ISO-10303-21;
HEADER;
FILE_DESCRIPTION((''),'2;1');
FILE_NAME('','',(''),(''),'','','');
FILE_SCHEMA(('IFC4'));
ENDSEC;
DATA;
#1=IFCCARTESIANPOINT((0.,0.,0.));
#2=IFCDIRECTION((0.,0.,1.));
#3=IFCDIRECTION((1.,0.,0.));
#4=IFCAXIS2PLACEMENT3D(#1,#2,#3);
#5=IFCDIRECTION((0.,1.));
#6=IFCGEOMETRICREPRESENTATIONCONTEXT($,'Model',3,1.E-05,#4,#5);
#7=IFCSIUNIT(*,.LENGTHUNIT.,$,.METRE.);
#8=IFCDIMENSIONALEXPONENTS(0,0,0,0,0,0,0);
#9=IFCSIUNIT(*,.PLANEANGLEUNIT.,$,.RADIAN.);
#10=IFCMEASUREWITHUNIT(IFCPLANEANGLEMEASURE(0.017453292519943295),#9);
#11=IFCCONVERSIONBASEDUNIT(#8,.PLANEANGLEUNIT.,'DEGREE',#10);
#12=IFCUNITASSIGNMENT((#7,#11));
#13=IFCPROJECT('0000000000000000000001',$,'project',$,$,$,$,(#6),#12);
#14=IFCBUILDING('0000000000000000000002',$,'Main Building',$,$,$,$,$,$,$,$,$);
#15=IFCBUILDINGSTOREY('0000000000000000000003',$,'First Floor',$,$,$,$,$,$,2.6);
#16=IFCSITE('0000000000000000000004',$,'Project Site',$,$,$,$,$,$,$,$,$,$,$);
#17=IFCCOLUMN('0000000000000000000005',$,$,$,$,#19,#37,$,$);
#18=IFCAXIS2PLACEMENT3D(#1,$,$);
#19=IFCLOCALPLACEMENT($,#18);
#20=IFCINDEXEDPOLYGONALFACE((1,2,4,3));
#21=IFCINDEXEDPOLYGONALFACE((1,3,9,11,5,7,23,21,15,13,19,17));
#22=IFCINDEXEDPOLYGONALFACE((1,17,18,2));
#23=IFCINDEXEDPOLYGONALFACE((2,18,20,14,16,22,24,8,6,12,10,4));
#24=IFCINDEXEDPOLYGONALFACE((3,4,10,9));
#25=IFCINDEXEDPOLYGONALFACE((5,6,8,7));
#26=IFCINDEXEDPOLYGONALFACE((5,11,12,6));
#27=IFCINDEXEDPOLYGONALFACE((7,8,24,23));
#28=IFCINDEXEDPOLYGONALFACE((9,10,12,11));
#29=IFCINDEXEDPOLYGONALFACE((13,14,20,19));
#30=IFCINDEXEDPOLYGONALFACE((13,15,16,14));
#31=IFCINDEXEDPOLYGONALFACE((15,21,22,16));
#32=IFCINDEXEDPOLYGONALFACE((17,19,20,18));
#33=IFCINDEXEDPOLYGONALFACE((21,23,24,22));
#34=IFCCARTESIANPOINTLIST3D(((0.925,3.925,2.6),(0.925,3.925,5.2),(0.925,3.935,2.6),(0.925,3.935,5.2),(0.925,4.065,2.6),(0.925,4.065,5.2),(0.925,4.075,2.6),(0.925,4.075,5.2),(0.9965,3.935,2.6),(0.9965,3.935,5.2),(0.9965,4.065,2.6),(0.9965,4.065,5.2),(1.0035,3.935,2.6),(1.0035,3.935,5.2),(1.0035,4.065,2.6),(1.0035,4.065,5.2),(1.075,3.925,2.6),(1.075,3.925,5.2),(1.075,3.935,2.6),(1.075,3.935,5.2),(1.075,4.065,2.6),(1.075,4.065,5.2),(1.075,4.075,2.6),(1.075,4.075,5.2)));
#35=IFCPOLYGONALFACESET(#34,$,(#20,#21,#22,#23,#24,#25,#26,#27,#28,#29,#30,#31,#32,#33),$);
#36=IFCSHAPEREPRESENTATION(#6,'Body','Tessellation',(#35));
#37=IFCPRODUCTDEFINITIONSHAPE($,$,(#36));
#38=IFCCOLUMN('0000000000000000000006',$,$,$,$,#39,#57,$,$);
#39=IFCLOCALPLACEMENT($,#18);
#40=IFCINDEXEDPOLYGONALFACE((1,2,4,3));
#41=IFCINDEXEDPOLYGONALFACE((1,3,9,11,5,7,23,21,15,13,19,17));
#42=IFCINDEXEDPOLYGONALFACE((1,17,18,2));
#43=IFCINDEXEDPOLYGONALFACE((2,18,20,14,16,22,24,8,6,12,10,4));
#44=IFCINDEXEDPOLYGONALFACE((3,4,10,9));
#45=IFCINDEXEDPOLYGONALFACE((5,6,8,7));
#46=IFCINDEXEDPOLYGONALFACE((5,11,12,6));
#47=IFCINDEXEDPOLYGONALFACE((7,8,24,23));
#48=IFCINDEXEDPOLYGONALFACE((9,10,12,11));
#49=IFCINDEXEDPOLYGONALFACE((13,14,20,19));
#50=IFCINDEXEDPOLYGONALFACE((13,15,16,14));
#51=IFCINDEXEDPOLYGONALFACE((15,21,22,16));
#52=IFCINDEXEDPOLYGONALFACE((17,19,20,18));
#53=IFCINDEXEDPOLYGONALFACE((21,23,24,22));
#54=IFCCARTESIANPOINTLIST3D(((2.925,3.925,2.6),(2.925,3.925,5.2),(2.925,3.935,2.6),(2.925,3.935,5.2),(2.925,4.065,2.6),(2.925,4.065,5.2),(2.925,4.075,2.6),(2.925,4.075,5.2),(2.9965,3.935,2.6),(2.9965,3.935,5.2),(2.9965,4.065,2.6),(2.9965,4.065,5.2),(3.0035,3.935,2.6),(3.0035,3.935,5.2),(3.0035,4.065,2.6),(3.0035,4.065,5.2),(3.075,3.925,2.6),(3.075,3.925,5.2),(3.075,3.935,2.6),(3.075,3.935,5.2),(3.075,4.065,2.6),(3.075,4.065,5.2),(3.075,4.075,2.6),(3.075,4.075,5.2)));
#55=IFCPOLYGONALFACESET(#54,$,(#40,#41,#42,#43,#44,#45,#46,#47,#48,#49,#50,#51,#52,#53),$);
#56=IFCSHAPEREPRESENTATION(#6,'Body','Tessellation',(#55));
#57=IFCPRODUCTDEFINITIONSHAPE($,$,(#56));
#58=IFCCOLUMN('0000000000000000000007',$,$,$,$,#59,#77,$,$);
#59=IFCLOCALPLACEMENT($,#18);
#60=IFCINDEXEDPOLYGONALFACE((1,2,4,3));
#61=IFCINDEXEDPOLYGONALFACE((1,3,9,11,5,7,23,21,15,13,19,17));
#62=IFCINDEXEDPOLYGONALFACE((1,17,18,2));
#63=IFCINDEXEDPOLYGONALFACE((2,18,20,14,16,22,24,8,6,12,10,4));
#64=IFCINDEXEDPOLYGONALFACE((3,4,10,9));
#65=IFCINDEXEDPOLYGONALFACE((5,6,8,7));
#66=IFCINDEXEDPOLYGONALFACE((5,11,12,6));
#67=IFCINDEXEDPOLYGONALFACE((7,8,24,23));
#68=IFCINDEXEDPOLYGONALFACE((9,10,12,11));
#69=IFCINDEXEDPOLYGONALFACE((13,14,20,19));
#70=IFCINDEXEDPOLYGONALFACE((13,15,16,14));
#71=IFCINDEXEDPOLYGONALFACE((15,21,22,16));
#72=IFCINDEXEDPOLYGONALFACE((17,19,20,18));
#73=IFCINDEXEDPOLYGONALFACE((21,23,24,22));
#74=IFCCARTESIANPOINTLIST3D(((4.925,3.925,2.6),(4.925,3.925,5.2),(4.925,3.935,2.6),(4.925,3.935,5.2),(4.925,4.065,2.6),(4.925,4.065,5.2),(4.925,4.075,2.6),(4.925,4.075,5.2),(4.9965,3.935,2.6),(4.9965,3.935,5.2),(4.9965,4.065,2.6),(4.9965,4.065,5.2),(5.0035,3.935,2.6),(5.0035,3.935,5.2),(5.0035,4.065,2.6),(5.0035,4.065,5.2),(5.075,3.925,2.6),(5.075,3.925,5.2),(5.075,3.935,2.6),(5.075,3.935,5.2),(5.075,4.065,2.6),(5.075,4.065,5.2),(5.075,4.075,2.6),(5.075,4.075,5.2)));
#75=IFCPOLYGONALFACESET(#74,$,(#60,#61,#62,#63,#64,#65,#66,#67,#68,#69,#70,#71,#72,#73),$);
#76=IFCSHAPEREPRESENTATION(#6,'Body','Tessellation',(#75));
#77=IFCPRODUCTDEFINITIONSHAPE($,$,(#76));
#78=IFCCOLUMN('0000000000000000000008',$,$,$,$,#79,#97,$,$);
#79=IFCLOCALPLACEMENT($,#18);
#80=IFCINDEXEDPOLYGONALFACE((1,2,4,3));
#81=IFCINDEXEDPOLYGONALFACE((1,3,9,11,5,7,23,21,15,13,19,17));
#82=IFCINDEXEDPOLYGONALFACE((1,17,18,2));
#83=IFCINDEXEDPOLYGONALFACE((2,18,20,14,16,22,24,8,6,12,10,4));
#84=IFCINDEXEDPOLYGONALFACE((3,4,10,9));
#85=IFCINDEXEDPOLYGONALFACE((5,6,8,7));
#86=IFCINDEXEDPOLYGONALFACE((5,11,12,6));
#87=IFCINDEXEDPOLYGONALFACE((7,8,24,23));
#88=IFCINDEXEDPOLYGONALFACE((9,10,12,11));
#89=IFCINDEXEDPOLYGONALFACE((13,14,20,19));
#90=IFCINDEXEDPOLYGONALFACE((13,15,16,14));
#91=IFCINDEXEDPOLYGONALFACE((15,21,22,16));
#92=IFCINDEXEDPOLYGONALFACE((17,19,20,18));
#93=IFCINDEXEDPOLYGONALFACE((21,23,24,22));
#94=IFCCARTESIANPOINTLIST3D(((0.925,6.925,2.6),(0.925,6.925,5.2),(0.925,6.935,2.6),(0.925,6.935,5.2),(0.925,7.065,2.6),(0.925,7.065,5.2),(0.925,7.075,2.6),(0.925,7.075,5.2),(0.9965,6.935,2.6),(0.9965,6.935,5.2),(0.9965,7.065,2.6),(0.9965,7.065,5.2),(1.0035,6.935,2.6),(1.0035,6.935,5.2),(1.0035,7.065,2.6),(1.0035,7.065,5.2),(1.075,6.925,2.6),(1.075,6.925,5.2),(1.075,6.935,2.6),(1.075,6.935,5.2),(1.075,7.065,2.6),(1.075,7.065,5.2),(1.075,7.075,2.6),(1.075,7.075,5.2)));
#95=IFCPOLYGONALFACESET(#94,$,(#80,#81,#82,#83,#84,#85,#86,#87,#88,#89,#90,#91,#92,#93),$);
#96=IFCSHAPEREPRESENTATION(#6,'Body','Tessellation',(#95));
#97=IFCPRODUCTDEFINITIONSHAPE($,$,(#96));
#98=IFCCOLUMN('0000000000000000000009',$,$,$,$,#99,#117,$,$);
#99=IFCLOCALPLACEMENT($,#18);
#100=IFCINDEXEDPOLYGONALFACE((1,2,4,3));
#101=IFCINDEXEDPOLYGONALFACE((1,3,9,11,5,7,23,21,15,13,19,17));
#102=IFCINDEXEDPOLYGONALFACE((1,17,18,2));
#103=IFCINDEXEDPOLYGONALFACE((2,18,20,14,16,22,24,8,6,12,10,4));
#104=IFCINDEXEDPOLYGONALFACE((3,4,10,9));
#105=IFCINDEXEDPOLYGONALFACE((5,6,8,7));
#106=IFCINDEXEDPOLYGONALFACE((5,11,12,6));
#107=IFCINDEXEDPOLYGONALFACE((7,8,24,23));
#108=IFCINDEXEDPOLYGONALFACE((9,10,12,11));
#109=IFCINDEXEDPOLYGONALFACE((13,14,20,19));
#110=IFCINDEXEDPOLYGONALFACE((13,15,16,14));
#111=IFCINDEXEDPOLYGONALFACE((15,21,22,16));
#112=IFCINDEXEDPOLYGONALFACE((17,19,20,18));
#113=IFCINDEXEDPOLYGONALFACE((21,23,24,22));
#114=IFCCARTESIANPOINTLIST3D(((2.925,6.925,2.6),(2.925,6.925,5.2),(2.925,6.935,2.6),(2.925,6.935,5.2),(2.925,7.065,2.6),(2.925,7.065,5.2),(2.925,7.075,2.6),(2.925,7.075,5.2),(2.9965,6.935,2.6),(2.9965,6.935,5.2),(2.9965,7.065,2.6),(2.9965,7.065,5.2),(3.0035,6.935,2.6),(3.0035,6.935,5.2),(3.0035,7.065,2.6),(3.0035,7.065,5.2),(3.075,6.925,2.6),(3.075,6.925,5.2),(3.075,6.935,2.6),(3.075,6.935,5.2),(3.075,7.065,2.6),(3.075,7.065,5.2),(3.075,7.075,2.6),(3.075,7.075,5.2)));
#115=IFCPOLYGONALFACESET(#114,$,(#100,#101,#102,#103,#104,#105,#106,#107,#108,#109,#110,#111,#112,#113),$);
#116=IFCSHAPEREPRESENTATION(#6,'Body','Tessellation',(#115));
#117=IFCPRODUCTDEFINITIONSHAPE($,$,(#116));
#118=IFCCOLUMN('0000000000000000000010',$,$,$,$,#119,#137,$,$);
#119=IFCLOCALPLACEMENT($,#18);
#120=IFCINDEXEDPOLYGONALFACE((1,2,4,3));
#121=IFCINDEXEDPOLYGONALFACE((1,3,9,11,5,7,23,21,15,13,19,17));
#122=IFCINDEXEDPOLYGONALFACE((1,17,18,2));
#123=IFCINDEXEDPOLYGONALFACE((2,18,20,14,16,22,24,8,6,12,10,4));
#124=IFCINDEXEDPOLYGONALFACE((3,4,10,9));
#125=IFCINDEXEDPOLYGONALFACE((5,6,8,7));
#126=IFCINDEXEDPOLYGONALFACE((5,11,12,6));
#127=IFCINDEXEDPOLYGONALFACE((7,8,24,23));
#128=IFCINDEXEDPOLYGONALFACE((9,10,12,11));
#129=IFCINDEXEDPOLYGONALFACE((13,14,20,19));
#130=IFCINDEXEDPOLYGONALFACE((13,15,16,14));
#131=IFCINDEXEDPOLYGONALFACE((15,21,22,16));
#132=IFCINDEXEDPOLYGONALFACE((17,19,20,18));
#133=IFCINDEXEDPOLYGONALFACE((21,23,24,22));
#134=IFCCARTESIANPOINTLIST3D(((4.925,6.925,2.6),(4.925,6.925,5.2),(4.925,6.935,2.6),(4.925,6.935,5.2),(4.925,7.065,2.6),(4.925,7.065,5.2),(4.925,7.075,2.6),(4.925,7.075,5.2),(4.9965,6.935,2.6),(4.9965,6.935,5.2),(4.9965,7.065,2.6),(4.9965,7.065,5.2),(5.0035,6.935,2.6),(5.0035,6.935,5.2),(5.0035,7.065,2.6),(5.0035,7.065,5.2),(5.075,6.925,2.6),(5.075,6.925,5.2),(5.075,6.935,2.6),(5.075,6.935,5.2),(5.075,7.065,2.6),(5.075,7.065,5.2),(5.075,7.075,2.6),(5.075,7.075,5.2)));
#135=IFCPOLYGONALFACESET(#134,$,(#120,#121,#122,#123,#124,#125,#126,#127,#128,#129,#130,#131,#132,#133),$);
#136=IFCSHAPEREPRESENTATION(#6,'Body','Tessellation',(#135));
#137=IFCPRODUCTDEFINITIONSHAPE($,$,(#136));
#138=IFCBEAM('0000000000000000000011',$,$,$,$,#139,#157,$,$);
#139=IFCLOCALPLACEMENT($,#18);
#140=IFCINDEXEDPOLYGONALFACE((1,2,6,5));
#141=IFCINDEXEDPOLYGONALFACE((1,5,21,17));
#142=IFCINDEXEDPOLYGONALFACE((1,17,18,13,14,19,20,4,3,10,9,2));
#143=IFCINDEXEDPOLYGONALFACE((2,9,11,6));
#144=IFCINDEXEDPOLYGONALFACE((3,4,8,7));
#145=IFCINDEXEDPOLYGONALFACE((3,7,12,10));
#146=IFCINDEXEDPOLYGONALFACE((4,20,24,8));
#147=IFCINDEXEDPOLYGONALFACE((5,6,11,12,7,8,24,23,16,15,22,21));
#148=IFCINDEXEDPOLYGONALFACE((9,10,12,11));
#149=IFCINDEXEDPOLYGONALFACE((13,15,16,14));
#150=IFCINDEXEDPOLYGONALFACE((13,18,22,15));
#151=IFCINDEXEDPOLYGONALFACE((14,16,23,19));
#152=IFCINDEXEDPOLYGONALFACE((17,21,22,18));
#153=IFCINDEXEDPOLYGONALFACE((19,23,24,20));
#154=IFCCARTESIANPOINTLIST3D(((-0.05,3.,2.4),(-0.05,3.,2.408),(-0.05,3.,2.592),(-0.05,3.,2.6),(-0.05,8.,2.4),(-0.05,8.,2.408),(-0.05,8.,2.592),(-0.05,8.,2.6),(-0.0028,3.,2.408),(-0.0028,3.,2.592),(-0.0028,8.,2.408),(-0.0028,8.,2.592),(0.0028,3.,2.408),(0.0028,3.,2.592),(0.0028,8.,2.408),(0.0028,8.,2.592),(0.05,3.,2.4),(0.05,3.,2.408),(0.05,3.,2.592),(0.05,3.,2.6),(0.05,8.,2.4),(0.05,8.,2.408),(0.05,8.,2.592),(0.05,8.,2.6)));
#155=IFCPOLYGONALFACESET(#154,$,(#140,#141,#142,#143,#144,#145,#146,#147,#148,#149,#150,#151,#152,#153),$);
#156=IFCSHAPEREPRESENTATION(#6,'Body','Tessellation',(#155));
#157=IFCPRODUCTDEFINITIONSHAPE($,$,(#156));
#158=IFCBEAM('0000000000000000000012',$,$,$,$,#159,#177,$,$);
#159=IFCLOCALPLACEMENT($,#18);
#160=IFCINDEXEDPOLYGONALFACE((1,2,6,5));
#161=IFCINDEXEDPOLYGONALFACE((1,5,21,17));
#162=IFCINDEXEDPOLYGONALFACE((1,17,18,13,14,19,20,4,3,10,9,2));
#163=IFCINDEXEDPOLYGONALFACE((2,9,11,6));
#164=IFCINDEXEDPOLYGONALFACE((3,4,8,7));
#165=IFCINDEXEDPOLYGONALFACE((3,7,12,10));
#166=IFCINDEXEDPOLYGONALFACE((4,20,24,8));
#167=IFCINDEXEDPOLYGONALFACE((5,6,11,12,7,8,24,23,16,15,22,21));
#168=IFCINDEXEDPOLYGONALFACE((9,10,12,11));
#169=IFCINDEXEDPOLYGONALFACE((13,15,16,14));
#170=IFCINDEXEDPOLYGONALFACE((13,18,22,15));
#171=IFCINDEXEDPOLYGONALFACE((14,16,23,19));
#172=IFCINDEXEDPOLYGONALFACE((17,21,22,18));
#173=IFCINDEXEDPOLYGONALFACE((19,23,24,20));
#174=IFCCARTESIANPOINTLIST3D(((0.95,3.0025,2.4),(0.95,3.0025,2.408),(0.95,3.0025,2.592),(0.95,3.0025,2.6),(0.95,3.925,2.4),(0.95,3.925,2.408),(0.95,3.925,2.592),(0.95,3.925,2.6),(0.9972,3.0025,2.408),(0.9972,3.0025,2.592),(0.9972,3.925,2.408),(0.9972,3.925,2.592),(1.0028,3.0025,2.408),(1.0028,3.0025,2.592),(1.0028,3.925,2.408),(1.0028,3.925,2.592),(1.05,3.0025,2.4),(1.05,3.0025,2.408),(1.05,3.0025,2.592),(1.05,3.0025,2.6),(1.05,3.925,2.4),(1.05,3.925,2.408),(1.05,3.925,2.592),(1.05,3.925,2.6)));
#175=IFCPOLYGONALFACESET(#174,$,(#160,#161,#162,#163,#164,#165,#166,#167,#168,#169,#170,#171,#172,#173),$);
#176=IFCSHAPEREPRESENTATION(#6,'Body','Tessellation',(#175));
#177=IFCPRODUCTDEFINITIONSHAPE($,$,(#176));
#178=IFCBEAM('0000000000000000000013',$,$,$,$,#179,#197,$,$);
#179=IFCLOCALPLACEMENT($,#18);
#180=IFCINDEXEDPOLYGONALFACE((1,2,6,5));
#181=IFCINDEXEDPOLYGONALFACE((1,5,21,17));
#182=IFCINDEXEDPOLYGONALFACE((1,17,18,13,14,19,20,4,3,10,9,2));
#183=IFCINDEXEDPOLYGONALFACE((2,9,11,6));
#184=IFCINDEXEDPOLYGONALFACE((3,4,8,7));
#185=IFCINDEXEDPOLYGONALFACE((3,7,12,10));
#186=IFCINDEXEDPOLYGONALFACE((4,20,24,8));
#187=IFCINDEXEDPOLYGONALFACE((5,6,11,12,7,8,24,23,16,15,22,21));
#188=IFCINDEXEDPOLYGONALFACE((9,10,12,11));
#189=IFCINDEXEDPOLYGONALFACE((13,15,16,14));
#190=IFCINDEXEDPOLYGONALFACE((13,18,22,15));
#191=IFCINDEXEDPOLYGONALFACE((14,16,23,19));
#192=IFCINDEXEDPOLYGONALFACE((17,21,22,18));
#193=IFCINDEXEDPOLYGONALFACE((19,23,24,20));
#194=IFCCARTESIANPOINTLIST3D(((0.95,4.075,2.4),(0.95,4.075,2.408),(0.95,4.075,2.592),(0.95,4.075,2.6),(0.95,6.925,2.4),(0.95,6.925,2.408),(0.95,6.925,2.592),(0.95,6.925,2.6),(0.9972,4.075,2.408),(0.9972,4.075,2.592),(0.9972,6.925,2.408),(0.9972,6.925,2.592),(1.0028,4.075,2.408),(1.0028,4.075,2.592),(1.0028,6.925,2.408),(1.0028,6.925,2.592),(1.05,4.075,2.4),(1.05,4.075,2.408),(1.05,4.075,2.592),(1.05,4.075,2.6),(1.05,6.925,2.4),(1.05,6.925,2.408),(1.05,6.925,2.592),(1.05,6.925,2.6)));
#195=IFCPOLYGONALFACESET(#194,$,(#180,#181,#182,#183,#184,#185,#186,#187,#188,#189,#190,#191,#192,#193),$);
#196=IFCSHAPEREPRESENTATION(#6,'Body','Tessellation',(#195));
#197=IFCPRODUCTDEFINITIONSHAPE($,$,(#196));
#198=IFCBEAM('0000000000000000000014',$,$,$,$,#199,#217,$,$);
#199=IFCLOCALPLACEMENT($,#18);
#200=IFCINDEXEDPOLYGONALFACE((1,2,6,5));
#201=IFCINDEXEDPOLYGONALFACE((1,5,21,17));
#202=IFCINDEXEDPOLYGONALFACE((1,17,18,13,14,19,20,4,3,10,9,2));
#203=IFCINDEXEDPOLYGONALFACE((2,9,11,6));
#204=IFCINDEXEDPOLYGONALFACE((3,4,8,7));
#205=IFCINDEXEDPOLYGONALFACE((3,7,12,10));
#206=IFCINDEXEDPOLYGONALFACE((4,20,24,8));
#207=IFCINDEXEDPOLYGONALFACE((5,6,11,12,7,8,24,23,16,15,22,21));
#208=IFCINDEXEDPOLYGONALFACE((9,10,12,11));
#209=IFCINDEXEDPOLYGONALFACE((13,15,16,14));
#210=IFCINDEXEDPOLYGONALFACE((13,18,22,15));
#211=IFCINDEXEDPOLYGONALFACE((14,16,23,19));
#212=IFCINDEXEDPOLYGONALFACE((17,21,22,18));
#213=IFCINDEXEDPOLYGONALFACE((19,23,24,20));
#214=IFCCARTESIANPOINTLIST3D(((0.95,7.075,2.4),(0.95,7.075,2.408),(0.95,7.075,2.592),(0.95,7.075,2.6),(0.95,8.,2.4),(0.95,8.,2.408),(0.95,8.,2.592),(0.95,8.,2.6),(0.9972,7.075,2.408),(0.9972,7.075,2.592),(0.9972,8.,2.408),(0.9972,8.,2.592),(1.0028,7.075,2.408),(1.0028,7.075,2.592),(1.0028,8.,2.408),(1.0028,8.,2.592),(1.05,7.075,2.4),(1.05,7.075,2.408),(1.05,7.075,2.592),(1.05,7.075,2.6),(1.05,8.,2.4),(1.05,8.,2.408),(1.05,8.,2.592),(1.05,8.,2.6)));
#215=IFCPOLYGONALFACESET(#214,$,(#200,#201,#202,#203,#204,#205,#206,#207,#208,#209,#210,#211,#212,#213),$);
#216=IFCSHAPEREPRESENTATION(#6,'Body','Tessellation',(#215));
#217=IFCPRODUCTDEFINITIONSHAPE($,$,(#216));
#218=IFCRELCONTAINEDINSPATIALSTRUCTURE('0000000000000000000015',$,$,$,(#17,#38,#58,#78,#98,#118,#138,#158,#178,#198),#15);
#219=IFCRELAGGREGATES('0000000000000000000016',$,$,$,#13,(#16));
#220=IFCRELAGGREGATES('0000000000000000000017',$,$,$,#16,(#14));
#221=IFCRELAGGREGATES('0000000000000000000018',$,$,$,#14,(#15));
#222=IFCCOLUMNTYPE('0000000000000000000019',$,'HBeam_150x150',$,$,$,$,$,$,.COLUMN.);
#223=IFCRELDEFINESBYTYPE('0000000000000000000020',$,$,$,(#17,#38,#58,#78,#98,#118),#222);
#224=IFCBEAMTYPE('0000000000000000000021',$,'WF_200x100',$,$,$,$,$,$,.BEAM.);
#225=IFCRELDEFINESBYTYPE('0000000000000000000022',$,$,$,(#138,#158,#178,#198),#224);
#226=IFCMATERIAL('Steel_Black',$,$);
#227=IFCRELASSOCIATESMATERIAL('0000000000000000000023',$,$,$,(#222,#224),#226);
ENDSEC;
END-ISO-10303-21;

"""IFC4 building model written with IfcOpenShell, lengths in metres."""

from ifc_helpers import new_model, entity, si_unit, converted_unit, direction, frame, frame_2d, origin, origin_with_axes, origin_2d, place, context, project, spatial, i_section, extrude, material, material_profile, profile_set, type_object, element, save


model = new_model("IFC4")

# Units and contexts
model_context = context("Model", 3, precision=1e-05, world=origin_with_axes(), true_north=direction((0.0, 1.0)))
ifc_project = project(units=[si_unit("LENGTHUNIT", "METRE"), converted_unit("PLANEANGLEUNIT", "DEGREE", entity("IfcPlaneAngleMeasure", 0.017453292519943295), si_unit("PLANEANGLEUNIT", "RADIAN"), dimensions=[0, 0, 0, 0, 0, 0, 0])], contexts=[model_context])

# Site, building, storey
site = spatial("IfcSite", under=ifc_project, Name="Project Site")
building = spatial("IfcBuilding", under=site, Name="Main Building")
storey = spatial("IfcBuildingStorey", under=building, Name="First Floor", Elevation=2.6)

# Columns
ifc_material_1 = material(Name="Steel_Black")
ifc_material_profile_1 = material_profile(ifc_material_1, i_section(OverallWidth=0.15, OverallDepth=0.15, WebThickness=0.007, FlangeThickness=0.01, at=origin_2d()), Name="HBeam_150x150")
ifc_profile_set_1 = profile_set([ifc_material_profile_1], Name="HBeam_150x150")
column_type = type_object("IfcColumnType", Name="HBeam_150x150", PredefinedType="COLUMN", material=ifc_profile_set_1)
for number, where, z_axis, x_axis in (
    (1, (1.0, 4.0, 2.6), (0.0, 0.0, 1.0), (1.0, 0.0, 0.0)),
    (2, (3.0, 4.0, 2.6), (0.0, 0.0, 1.0), (1.0, 0.0, 0.0)),
    (3, (5.0, 4.0, 2.6), (0.0, 0.0, 1.0), (1.0, 0.0, 0.0)),
    (4, (1.0, 7.0, 2.6), (0.0, 0.0, 1.0), (1.0, 0.0, 0.0)),
    (5, (3.0, 7.0, 2.6), (0.0, 0.0, 1.0), (1.0, 0.0, 0.0)),
    (6, (5.0, 7.0, 2.6), (0.0, 0.0, 1.0), (1.0, 0.0, 0.0)),
):
    element("IfcColumn", number, at=place(None, frame(where, z_axis=z_axis, x_axis=x_axis)), inside=storey, type_object=column_type, context=model_context, shape_type="SweptSolid", body=[
        extrude(i_section(OverallWidth=0.15, OverallDepth=0.15, WebThickness=0.007, FlangeThickness=0.01, at=origin_2d()), origin(), (0.0, 0.0, 1.0), 2.6),
    ])

# Beams
ifc_material_profile_2 = material_profile(ifc_material_1, i_section(OverallWidth=0.1, OverallDepth=0.2, WebThickness=0.0055, FlangeThickness=0.008, at=origin_2d()), Name="WF_200x100")
ifc_profile_set_2 = profile_set([ifc_material_profile_2], Name="WF_200x100")
beam_type_1 = type_object("IfcBeamType", Name="WF_200x100", PredefinedType="BEAM", material=ifc_profile_set_2)
beam_1_placement = place(None, frame((0.0, 3.0, 2.4), z_axis=(0.0, 0.0, 1.0), x_axis=(0.0, 1.0, 0.0)))
element("IfcBeam", 7, at=beam_1_placement, inside=storey, type_object=beam_type_1, context=model_context, shape_type="SweptSolid", body=[
    extrude(i_section(OverallWidth=0.1, OverallDepth=0.2, WebThickness=0.0055, FlangeThickness=0.008, at=frame_2d((0.0, 0.1))), frame((0.0, 0.0, 0.0), z_axis=(1.0, 0.0, 0.0), x_axis=(0.0, 1.0, 0.0)), (0.0, 0.0, 1.0), 5.0),
])
beam_2_placement = place(None, frame((1.0, 3.0025, 2.4), z_axis=(0.0, 0.0, 1.0), x_axis=(0.0, 1.0, 0.0)))
element("IfcBeam", 8, at=beam_2_placement, inside=storey, type_object=beam_type_1, context=model_context, shape_type="SweptSolid", body=[
    extrude(i_section(OverallWidth=0.1, OverallDepth=0.2, WebThickness=0.0055, FlangeThickness=0.008, at=frame_2d((0.0, 0.1))), frame((0.0, 0.0, 0.0), z_axis=(1.0, 0.0, 0.0), x_axis=(0.0, 1.0, 0.0)), (0.0, 0.0, 1.0), 0.9225),
])
beam_3_placement = place(None, frame((1.0, 4.075, 2.4), z_axis=(0.0, 0.0, 1.0), x_axis=(0.0, 1.0, 0.0)))
element("IfcBeam", 9, at=beam_3_placement, inside=storey, type_object=beam_type_1, context=model_context, shape_type="SweptSolid", body=[
    extrude(i_section(OverallWidth=0.1, OverallDepth=0.2, WebThickness=0.0055, FlangeThickness=0.008, at=frame_2d((0.0, 0.1))), frame((0.0, 0.0, 0.0), z_axis=(1.0, 0.0, 0.0), x_axis=(0.0, 1.0, 0.0)), (0.0, 0.0, 1.0), 2.85),
])
beam_4_placement = place(None, frame((1.0, 7.075, 2.4), z_axis=(0.0, 0.0, 1.0), x_axis=(0.0, 1.0, 0.0)))
element("IfcBeam", 10, at=beam_4_placement, inside=storey, type_object=beam_type_1, context=model_context, shape_type="SweptSolid", body=[
    extrude(i_section(OverallWidth=0.1, OverallDepth=0.2, WebThickness=0.0055, FlangeThickness=0.008, at=frame_2d((0.0, 0.1))), frame((0.0, 0.0, 0.0), z_axis=(1.0, 0.0, 0.0), x_axis=(0.0, 1.0, 0.0)), (0.0, 0.0, 1.0), 0.925),
])

save(model, "model.ifc")
